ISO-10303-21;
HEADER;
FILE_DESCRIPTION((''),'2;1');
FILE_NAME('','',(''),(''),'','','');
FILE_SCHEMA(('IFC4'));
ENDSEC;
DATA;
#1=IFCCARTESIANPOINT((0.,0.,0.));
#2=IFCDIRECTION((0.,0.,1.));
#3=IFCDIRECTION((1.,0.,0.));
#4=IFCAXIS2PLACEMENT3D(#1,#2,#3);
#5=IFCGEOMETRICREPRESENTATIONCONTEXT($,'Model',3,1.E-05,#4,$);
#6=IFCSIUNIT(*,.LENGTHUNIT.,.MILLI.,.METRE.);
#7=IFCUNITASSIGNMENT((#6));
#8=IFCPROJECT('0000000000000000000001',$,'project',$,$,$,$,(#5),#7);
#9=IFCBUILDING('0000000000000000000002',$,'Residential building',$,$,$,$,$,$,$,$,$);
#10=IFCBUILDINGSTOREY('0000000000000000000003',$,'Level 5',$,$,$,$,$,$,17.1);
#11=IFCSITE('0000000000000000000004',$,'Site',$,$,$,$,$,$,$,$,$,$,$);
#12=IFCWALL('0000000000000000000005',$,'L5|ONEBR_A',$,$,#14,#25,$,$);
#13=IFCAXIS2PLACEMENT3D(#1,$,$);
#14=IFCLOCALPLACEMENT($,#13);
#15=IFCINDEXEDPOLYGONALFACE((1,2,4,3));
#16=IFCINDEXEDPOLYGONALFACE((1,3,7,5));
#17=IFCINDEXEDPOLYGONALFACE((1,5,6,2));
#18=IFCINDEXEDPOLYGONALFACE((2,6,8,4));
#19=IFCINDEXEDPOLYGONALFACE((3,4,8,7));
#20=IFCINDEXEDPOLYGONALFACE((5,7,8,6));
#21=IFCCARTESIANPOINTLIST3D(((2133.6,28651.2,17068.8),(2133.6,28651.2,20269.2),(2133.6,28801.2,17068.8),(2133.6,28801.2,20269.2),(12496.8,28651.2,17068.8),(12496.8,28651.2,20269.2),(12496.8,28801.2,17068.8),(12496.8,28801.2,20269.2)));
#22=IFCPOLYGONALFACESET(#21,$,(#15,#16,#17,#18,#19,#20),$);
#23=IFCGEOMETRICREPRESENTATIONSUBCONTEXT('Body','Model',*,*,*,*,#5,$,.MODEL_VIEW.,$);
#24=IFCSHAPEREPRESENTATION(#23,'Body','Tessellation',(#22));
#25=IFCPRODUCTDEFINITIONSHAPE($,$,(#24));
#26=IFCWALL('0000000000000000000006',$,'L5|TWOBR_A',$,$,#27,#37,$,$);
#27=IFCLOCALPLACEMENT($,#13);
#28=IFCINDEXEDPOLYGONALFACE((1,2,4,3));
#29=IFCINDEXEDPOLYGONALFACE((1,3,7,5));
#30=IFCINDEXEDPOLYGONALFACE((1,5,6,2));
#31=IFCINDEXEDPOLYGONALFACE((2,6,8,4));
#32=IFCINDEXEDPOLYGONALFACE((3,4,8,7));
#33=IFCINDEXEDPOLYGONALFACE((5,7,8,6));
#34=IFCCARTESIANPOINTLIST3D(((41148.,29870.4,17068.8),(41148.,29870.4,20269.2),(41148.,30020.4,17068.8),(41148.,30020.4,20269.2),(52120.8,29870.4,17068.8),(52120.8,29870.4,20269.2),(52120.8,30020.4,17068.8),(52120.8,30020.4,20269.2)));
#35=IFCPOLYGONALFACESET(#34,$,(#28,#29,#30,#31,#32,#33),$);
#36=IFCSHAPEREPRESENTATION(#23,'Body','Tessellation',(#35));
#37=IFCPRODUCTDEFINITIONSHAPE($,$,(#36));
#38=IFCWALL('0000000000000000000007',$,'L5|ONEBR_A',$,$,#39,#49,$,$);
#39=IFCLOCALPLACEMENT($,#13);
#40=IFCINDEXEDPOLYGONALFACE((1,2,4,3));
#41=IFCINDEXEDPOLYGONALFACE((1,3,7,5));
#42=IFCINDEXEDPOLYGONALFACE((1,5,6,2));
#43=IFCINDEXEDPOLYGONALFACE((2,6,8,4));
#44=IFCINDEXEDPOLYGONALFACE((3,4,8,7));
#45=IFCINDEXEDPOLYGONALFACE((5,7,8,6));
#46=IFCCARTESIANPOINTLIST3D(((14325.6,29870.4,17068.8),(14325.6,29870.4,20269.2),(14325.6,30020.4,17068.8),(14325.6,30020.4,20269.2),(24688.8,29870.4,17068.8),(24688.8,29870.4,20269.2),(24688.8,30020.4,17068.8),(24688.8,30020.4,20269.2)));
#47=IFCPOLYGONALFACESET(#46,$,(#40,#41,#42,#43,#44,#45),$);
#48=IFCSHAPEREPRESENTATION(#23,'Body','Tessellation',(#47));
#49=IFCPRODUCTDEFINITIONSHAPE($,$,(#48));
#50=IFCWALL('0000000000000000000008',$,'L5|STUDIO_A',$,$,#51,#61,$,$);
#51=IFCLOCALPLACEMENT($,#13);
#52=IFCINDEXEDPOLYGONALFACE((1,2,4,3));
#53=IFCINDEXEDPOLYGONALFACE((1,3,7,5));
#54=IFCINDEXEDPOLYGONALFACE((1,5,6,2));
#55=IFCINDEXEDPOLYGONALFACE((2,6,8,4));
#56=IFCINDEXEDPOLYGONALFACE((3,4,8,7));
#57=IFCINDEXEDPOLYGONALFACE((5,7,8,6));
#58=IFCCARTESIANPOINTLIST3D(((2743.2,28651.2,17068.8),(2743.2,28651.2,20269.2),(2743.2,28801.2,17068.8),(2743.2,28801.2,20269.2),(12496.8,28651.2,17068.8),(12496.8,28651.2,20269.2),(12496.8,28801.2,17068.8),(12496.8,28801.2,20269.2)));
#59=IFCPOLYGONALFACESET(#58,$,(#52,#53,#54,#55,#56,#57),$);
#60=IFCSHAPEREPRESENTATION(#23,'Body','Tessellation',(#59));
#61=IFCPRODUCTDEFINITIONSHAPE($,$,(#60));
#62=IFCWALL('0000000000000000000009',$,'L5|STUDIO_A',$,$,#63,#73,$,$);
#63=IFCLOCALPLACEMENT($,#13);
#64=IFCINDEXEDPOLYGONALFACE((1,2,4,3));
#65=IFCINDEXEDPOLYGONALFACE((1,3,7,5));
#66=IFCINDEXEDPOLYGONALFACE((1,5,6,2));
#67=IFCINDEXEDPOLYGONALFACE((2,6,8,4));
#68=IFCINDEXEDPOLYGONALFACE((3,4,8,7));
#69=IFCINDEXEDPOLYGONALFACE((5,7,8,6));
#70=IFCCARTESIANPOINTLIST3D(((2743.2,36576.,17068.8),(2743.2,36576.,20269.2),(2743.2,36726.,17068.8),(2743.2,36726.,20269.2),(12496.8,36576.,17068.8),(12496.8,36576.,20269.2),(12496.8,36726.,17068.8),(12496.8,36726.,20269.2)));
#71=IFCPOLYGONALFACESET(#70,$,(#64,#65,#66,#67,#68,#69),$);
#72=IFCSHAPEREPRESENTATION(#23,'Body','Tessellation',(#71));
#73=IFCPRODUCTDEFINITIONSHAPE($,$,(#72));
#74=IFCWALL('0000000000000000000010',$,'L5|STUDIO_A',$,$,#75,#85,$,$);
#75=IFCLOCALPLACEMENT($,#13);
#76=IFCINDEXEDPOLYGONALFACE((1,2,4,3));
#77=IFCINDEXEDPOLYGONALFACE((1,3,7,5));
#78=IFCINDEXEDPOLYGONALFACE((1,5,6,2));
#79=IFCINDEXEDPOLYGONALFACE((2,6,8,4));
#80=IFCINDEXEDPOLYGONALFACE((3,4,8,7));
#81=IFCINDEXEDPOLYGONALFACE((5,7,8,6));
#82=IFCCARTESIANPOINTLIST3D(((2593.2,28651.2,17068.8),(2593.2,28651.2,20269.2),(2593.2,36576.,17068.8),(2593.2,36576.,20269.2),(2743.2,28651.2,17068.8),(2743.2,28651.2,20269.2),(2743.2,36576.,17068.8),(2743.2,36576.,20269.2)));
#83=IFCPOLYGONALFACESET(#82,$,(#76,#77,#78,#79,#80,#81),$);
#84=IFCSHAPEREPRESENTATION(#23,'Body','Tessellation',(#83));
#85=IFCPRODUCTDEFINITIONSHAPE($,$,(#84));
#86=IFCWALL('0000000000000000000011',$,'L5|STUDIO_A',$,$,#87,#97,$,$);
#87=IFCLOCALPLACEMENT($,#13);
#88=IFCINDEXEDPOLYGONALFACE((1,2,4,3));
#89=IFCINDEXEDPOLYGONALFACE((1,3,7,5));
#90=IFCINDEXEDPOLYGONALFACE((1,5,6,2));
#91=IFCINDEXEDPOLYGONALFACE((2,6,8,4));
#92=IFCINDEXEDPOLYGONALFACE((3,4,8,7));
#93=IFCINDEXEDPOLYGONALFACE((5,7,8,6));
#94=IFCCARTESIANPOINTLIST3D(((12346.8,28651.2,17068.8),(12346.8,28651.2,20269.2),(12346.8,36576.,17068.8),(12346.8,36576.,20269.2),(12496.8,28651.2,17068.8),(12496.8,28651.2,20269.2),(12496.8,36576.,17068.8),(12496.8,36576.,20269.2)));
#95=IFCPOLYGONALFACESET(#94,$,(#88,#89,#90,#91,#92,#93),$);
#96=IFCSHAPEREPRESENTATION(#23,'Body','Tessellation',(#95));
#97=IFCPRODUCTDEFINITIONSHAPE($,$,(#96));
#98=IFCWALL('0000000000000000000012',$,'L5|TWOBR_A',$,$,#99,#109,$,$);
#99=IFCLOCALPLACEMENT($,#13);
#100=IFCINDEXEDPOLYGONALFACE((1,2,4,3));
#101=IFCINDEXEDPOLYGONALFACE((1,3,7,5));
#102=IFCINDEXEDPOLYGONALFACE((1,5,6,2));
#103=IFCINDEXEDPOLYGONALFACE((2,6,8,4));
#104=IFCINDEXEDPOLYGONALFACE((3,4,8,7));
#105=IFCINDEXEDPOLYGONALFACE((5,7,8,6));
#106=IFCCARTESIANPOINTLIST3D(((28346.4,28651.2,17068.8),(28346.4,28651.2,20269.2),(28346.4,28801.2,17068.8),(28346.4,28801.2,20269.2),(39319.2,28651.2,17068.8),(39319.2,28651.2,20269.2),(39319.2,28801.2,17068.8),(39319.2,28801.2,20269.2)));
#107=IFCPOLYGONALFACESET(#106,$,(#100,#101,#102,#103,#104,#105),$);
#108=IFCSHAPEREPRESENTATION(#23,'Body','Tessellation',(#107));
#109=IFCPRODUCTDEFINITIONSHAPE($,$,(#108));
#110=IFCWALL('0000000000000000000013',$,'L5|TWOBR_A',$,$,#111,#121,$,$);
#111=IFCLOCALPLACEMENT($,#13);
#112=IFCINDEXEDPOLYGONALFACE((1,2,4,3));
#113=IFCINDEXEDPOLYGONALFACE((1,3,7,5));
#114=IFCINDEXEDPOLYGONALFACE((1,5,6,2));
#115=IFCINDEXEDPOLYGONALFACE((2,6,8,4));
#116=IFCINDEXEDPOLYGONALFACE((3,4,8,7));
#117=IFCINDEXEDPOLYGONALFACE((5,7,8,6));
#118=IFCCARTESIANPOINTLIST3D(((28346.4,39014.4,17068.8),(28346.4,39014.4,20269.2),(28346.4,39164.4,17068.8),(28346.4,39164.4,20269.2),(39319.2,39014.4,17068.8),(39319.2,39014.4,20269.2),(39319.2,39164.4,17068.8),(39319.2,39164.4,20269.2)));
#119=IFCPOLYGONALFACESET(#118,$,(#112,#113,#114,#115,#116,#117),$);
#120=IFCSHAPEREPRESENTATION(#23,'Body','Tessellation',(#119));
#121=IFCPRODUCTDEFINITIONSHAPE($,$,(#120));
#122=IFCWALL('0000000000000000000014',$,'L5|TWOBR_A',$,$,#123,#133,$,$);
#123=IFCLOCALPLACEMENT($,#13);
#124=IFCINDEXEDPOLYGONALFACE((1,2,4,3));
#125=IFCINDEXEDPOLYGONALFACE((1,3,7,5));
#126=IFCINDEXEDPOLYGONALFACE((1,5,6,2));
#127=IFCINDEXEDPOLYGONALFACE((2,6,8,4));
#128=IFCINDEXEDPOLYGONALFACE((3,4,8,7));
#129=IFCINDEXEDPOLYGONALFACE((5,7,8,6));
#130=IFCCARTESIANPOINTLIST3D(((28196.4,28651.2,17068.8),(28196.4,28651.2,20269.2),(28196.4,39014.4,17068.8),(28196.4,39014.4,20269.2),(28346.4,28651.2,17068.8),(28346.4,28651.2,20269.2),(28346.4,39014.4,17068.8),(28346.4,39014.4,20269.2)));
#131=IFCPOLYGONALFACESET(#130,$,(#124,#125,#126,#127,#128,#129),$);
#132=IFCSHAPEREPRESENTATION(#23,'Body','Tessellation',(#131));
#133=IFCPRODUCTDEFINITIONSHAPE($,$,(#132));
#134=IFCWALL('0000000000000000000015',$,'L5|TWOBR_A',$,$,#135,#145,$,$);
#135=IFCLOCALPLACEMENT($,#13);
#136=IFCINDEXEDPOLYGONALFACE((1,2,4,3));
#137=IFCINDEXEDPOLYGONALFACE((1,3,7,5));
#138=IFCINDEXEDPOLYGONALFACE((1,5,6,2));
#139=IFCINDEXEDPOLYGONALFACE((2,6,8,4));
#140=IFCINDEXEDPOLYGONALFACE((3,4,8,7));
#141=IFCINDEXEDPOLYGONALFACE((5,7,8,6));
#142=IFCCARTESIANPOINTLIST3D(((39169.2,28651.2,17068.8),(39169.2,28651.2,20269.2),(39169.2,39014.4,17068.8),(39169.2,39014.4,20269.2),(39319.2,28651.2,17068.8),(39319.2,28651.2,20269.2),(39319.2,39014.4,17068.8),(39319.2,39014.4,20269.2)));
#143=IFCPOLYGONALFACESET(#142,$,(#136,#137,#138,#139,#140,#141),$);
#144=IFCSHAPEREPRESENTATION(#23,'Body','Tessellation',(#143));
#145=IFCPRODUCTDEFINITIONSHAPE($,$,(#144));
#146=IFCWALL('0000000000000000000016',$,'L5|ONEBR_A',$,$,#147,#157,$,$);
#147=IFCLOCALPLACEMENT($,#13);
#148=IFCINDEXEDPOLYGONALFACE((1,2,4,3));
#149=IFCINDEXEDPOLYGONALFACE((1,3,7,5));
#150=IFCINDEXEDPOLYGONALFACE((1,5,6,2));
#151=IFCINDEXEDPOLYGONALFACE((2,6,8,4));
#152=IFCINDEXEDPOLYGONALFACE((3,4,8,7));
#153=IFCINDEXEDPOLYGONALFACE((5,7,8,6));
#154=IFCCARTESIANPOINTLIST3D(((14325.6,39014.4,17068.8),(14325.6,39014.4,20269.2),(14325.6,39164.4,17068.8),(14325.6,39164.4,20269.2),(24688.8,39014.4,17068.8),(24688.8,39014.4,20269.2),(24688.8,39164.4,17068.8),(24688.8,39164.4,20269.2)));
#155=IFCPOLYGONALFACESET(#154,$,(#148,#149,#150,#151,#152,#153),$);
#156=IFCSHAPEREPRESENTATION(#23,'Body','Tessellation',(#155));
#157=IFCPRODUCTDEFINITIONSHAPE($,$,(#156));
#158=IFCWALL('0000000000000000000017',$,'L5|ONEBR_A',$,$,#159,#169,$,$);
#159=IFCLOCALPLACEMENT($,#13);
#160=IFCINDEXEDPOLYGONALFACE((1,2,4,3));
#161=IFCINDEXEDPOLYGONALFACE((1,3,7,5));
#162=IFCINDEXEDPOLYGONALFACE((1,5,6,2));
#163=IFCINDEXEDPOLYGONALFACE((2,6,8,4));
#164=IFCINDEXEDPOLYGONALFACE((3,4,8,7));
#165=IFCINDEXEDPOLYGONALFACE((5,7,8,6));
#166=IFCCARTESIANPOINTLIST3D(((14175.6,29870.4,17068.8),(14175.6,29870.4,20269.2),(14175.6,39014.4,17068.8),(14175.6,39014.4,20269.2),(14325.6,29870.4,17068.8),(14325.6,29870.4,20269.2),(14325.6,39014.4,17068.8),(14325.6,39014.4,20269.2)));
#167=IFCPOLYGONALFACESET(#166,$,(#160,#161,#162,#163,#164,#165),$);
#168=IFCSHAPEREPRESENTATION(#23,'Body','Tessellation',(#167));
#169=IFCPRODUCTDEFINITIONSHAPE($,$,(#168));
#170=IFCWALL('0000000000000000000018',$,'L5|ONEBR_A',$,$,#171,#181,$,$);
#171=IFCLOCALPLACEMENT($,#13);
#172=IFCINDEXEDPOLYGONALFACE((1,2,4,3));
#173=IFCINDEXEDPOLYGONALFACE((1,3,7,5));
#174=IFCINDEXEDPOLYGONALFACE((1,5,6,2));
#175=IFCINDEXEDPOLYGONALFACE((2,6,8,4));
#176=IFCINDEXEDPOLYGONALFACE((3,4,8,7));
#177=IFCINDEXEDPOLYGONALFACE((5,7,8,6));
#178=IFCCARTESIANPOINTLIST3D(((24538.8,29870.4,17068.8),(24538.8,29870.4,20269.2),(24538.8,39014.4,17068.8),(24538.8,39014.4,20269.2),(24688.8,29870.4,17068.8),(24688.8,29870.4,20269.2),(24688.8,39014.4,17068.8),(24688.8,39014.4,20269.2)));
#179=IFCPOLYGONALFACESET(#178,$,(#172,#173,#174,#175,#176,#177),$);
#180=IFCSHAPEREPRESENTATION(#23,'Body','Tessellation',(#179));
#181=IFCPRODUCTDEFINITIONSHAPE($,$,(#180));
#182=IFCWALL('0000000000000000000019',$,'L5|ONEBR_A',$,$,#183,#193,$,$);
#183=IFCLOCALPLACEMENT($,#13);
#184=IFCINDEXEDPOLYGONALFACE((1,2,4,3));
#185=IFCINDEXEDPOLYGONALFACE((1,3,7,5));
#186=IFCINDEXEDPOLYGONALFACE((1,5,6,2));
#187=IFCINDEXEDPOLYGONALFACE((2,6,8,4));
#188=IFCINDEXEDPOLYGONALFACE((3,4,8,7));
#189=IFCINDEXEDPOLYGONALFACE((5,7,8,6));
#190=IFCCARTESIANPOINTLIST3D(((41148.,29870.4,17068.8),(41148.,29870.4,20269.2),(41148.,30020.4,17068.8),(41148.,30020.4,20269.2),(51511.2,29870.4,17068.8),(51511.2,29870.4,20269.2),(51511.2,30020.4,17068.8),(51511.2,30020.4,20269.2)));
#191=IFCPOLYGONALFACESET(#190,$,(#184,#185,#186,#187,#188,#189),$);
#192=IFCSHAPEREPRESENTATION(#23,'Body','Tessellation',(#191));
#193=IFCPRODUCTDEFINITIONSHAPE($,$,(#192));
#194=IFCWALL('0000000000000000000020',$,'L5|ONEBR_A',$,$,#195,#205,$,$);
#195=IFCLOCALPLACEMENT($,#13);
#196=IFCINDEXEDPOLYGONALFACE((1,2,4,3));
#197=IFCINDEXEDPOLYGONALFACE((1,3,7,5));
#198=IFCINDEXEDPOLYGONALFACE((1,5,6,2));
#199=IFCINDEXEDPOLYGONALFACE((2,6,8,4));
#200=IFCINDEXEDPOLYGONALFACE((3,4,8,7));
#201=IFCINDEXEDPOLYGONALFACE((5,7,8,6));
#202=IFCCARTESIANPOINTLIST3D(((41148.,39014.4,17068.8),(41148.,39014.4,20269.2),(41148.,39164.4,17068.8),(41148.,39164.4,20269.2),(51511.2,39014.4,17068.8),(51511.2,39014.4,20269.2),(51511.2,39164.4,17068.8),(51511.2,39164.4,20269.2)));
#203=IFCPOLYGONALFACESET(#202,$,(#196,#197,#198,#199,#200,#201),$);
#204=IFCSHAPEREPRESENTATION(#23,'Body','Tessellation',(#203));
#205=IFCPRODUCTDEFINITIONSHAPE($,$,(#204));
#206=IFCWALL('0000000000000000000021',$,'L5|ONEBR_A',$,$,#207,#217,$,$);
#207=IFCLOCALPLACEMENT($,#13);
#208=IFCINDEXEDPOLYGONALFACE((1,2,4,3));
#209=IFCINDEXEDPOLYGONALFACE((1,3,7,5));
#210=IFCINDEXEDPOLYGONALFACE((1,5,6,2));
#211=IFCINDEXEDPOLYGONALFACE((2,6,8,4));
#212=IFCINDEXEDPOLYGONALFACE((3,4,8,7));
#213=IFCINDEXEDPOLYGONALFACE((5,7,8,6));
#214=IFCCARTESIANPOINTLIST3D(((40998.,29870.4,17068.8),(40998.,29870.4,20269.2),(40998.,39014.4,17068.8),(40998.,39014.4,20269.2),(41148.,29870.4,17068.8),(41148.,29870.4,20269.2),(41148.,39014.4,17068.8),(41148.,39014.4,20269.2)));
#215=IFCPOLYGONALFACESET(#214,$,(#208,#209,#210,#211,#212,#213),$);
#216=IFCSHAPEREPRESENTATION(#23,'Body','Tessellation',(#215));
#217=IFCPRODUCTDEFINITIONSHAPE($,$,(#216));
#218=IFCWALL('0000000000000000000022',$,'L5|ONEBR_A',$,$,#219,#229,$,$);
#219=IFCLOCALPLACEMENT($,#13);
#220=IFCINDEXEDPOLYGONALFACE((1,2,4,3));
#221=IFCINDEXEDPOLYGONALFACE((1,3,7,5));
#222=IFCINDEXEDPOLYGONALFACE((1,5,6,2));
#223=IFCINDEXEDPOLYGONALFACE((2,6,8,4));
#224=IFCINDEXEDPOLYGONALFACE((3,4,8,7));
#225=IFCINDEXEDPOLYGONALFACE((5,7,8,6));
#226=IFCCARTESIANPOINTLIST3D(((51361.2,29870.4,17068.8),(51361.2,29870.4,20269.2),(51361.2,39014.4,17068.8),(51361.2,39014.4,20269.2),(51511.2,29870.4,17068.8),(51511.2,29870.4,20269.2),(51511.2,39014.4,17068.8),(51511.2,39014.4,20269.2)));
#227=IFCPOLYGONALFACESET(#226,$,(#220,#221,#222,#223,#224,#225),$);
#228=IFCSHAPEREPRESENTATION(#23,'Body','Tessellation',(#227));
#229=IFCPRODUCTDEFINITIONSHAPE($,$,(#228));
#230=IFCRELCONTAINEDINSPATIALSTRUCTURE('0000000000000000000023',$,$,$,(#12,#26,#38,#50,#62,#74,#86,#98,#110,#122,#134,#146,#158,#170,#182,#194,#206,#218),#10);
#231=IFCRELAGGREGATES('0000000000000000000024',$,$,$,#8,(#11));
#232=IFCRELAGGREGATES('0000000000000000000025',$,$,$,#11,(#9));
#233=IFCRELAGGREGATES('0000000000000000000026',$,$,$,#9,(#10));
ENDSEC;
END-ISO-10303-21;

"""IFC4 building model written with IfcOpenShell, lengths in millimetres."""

from ifc_helpers import new_model, si_unit, frame, origin_with_axes, place, context, subcontext, project, spatial, indexed_curve, outline, extrude, element, save


model = new_model("IFC4")

# Units and contexts
model_context = context("Model", 3, precision=1e-05, world=origin_with_axes())
body_context = subcontext(model_context, "Body", "Model", "MODEL_VIEW")
ifc_project = project(units=[si_unit("LENGTHUNIT", "METRE", prefix="MILLI")], contexts=[model_context])

# Site, building, storey
site = spatial("IfcSite", under=ifc_project, Name="Site")
building = spatial("IfcBuilding", under=site, Name="Residential building")
storey = spatial("IfcBuildingStorey", under=building, Name="Level 5", Elevation=17.1)

# Walls
wall_1_placement = place(None, frame((2133.6, 28651.2, 17068.8), z_axis=(0.0, 0.0, 1.0), x_axis=(1.0, 0.0, 0.0)))
element("IfcWall", 1, at=wall_1_placement, inside=storey, Name="L5|ONEBR_A", context=body_context, shape_type="SweptSolid", body=[
    extrude(outline(indexed_curve([(0.0, 0.0), (0.0, 150.0), (10363.2, 150.0), (10363.2, 0.0), (0.0, 0.0)], self_intersect=False)), origin_with_axes(), (0.0, 0.0, 1.0), 3200.4),
])
wall_2_placement = place(None, frame((41148.0, 29870.4, 17068.8), z_axis=(0.0, 0.0, 1.0), x_axis=(1.0, 0.0, 0.0)))
element("IfcWall", 2, at=wall_2_placement, inside=storey, Name="L5|TWOBR_A", context=body_context, shape_type="SweptSolid", body=[
    extrude(outline(indexed_curve([(0.0, 0.0), (0.0, 150.0), (10972.8, 150.0), (10972.8, 0.0), (0.0, 0.0)], self_intersect=False)), origin_with_axes(), (0.0, 0.0, 1.0), 3200.4),
])
wall_3_placement = place(None, frame((14325.6, 29870.4, 17068.8), z_axis=(0.0, 0.0, 1.0), x_axis=(1.0, 0.0, 0.0)))
element("IfcWall", 3, at=wall_3_placement, inside=storey, Name="L5|ONEBR_A", context=body_context, shape_type="SweptSolid", body=[
    extrude(outline(indexed_curve([(0.0, 0.0), (0.0, 150.0), (10363.2, 150.0), (10363.2, 0.0), (0.0, 0.0)], self_intersect=False)), origin_with_axes(), (0.0, 0.0, 1.0), 3200.4),
])
for number, where, z_axis, x_axis, name in (
    (4, (2743.2, 28651.2, 17068.8), (0.0, 0.0, 1.0), (1.0, 0.0, 0.0), "L5|STUDIO_A"),
    (5, (2743.2, 36576.0, 17068.8), (0.0, 0.0, 1.0), (1.0, 0.0, 0.0), "L5|STUDIO_A"),
):
    element("IfcWall", number, at=place(None, frame(where, z_axis=z_axis, x_axis=x_axis)), inside=storey, Name=name, context=body_context, shape_type="SweptSolid", body=[
        extrude(outline(indexed_curve([(0.0, 0.0), (0.0, 150.0), (9753.6, 150.0), (9753.6, 0.0), (0.0, 0.0)], self_intersect=False)), origin_with_axes(), (0.0, 0.0, 1.0), 3200.4),
    ])
for number, where, z_axis, x_axis, name in (
    (6, (2743.2, 28651.2, 17068.8), (0.0, 0.0, 1.0), (0.0, 1.0, 0.0), "L5|STUDIO_A"),
    (7, (12496.8, 28651.2, 17068.8), (0.0, 0.0, 1.0), (0.0, 1.0, 0.0), "L5|STUDIO_A"),
):
    element("IfcWall", number, at=place(None, frame(where, z_axis=z_axis, x_axis=x_axis)), inside=storey, Name=name, context=body_context, shape_type="SweptSolid", body=[
        extrude(outline(indexed_curve([(0.0, 0.0), (0.0, 150.0), (7924.8, 150.0), (7924.8, 0.0), (0.0, 0.0)], self_intersect=False)), origin_with_axes(), (0.0, 0.0, 1.0), 3200.4),
    ])
for number, where, z_axis, x_axis, name in (
    (8, (28346.4, 28651.2, 17068.8), (0.0, 0.0, 1.0), (1.0, 0.0, 0.0), "L5|TWOBR_A"),
    (9, (28346.4, 39014.4, 17068.8), (0.0, 0.0, 1.0), (1.0, 0.0, 0.0), "L5|TWOBR_A"),
):
    element("IfcWall", number, at=place(None, frame(where, z_axis=z_axis, x_axis=x_axis)), inside=storey, Name=name, context=body_context, shape_type="SweptSolid", body=[
        extrude(outline(indexed_curve([(0.0, 0.0), (0.0, 150.0), (10972.8, 150.0), (10972.8, 0.0), (0.0, 0.0)], self_intersect=False)), origin_with_axes(), (0.0, 0.0, 1.0), 3200.4),
    ])
for number, where, z_axis, x_axis, name in (
    (10, (28346.4, 28651.2, 17068.8), (0.0, 0.0, 1.0), (0.0, 1.0, 0.0), "L5|TWOBR_A"),
    (11, (39319.2, 28651.2, 17068.8), (0.0, 0.0, 1.0), (0.0, 1.0, 0.0), "L5|TWOBR_A"),
    (12, (14325.6, 39014.4, 17068.8), (0.0, 0.0, 1.0), (1.0, 0.0, 0.0), "L5|ONEBR_A"),
):
    element("IfcWall", number, at=place(None, frame(where, z_axis=z_axis, x_axis=x_axis)), inside=storey, Name=name, context=body_context, shape_type="SweptSolid", body=[
        extrude(outline(indexed_curve([(0.0, 0.0), (0.0, 150.0), (10363.2, 150.0), (10363.2, 0.0), (0.0, 0.0)], self_intersect=False)), origin_with_axes(), (0.0, 0.0, 1.0), 3200.4),
    ])
for number, where, z_axis, x_axis, name in (
    (13, (14325.6, 29870.4, 17068.8), (0.0, 0.0, 1.0), (0.0, 1.0, 0.0), "L5|ONEBR_A"),
    (14, (24688.8, 29870.4, 17068.8), (0.0, 0.0, 1.0), (0.0, 1.0, 0.0), "L5|ONEBR_A"),
):
    element("IfcWall", number, at=place(None, frame(where, z_axis=z_axis, x_axis=x_axis)), inside=storey, Name=name, context=body_context, shape_type="SweptSolid", body=[
        extrude(outline(indexed_curve([(0.0, 0.0), (0.0, 150.0), (9144.0, 150.0), (9144.0, 0.0), (0.0, 0.0)], self_intersect=False)), origin_with_axes(), (0.0, 0.0, 1.0), 3200.4),
    ])
for number, where, z_axis, x_axis, name in (
    (15, (41148.0, 29870.4, 17068.8), (0.0, 0.0, 1.0), (1.0, 0.0, 0.0), "L5|ONEBR_A"),
    (16, (41148.0, 39014.4, 17068.8), (0.0, 0.0, 1.0), (1.0, 0.0, 0.0), "L5|ONEBR_A"),
):
    element("IfcWall", number, at=place(None, frame(where, z_axis=z_axis, x_axis=x_axis)), inside=storey, Name=name, context=body_context, shape_type="SweptSolid", body=[
        extrude(outline(indexed_curve([(0.0, 0.0), (0.0, 150.0), (10363.2, 150.0), (10363.2, 0.0), (0.0, 0.0)], self_intersect=False)), origin_with_axes(), (0.0, 0.0, 1.0), 3200.4),
    ])
for number, where, z_axis, x_axis, name in (
    (17, (41148.0, 29870.4, 17068.8), (0.0, 0.0, 1.0), (0.0, 1.0, 0.0), "L5|ONEBR_A"),
    (18, (51511.2, 29870.4, 17068.8), (0.0, 0.0, 1.0), (0.0, 1.0, 0.0), "L5|ONEBR_A"),
):
    element("IfcWall", number, at=place(None, frame(where, z_axis=z_axis, x_axis=x_axis)), inside=storey, Name=name, context=body_context, shape_type="SweptSolid", body=[
        extrude(outline(indexed_curve([(0.0, 0.0), (0.0, 150.0), (9144.0, 150.0), (9144.0, 0.0), (0.0, 0.0)], self_intersect=False)), origin_with_axes(), (0.0, 0.0, 1.0), 3200.4),
    ])

save(model, "model.ifc")
